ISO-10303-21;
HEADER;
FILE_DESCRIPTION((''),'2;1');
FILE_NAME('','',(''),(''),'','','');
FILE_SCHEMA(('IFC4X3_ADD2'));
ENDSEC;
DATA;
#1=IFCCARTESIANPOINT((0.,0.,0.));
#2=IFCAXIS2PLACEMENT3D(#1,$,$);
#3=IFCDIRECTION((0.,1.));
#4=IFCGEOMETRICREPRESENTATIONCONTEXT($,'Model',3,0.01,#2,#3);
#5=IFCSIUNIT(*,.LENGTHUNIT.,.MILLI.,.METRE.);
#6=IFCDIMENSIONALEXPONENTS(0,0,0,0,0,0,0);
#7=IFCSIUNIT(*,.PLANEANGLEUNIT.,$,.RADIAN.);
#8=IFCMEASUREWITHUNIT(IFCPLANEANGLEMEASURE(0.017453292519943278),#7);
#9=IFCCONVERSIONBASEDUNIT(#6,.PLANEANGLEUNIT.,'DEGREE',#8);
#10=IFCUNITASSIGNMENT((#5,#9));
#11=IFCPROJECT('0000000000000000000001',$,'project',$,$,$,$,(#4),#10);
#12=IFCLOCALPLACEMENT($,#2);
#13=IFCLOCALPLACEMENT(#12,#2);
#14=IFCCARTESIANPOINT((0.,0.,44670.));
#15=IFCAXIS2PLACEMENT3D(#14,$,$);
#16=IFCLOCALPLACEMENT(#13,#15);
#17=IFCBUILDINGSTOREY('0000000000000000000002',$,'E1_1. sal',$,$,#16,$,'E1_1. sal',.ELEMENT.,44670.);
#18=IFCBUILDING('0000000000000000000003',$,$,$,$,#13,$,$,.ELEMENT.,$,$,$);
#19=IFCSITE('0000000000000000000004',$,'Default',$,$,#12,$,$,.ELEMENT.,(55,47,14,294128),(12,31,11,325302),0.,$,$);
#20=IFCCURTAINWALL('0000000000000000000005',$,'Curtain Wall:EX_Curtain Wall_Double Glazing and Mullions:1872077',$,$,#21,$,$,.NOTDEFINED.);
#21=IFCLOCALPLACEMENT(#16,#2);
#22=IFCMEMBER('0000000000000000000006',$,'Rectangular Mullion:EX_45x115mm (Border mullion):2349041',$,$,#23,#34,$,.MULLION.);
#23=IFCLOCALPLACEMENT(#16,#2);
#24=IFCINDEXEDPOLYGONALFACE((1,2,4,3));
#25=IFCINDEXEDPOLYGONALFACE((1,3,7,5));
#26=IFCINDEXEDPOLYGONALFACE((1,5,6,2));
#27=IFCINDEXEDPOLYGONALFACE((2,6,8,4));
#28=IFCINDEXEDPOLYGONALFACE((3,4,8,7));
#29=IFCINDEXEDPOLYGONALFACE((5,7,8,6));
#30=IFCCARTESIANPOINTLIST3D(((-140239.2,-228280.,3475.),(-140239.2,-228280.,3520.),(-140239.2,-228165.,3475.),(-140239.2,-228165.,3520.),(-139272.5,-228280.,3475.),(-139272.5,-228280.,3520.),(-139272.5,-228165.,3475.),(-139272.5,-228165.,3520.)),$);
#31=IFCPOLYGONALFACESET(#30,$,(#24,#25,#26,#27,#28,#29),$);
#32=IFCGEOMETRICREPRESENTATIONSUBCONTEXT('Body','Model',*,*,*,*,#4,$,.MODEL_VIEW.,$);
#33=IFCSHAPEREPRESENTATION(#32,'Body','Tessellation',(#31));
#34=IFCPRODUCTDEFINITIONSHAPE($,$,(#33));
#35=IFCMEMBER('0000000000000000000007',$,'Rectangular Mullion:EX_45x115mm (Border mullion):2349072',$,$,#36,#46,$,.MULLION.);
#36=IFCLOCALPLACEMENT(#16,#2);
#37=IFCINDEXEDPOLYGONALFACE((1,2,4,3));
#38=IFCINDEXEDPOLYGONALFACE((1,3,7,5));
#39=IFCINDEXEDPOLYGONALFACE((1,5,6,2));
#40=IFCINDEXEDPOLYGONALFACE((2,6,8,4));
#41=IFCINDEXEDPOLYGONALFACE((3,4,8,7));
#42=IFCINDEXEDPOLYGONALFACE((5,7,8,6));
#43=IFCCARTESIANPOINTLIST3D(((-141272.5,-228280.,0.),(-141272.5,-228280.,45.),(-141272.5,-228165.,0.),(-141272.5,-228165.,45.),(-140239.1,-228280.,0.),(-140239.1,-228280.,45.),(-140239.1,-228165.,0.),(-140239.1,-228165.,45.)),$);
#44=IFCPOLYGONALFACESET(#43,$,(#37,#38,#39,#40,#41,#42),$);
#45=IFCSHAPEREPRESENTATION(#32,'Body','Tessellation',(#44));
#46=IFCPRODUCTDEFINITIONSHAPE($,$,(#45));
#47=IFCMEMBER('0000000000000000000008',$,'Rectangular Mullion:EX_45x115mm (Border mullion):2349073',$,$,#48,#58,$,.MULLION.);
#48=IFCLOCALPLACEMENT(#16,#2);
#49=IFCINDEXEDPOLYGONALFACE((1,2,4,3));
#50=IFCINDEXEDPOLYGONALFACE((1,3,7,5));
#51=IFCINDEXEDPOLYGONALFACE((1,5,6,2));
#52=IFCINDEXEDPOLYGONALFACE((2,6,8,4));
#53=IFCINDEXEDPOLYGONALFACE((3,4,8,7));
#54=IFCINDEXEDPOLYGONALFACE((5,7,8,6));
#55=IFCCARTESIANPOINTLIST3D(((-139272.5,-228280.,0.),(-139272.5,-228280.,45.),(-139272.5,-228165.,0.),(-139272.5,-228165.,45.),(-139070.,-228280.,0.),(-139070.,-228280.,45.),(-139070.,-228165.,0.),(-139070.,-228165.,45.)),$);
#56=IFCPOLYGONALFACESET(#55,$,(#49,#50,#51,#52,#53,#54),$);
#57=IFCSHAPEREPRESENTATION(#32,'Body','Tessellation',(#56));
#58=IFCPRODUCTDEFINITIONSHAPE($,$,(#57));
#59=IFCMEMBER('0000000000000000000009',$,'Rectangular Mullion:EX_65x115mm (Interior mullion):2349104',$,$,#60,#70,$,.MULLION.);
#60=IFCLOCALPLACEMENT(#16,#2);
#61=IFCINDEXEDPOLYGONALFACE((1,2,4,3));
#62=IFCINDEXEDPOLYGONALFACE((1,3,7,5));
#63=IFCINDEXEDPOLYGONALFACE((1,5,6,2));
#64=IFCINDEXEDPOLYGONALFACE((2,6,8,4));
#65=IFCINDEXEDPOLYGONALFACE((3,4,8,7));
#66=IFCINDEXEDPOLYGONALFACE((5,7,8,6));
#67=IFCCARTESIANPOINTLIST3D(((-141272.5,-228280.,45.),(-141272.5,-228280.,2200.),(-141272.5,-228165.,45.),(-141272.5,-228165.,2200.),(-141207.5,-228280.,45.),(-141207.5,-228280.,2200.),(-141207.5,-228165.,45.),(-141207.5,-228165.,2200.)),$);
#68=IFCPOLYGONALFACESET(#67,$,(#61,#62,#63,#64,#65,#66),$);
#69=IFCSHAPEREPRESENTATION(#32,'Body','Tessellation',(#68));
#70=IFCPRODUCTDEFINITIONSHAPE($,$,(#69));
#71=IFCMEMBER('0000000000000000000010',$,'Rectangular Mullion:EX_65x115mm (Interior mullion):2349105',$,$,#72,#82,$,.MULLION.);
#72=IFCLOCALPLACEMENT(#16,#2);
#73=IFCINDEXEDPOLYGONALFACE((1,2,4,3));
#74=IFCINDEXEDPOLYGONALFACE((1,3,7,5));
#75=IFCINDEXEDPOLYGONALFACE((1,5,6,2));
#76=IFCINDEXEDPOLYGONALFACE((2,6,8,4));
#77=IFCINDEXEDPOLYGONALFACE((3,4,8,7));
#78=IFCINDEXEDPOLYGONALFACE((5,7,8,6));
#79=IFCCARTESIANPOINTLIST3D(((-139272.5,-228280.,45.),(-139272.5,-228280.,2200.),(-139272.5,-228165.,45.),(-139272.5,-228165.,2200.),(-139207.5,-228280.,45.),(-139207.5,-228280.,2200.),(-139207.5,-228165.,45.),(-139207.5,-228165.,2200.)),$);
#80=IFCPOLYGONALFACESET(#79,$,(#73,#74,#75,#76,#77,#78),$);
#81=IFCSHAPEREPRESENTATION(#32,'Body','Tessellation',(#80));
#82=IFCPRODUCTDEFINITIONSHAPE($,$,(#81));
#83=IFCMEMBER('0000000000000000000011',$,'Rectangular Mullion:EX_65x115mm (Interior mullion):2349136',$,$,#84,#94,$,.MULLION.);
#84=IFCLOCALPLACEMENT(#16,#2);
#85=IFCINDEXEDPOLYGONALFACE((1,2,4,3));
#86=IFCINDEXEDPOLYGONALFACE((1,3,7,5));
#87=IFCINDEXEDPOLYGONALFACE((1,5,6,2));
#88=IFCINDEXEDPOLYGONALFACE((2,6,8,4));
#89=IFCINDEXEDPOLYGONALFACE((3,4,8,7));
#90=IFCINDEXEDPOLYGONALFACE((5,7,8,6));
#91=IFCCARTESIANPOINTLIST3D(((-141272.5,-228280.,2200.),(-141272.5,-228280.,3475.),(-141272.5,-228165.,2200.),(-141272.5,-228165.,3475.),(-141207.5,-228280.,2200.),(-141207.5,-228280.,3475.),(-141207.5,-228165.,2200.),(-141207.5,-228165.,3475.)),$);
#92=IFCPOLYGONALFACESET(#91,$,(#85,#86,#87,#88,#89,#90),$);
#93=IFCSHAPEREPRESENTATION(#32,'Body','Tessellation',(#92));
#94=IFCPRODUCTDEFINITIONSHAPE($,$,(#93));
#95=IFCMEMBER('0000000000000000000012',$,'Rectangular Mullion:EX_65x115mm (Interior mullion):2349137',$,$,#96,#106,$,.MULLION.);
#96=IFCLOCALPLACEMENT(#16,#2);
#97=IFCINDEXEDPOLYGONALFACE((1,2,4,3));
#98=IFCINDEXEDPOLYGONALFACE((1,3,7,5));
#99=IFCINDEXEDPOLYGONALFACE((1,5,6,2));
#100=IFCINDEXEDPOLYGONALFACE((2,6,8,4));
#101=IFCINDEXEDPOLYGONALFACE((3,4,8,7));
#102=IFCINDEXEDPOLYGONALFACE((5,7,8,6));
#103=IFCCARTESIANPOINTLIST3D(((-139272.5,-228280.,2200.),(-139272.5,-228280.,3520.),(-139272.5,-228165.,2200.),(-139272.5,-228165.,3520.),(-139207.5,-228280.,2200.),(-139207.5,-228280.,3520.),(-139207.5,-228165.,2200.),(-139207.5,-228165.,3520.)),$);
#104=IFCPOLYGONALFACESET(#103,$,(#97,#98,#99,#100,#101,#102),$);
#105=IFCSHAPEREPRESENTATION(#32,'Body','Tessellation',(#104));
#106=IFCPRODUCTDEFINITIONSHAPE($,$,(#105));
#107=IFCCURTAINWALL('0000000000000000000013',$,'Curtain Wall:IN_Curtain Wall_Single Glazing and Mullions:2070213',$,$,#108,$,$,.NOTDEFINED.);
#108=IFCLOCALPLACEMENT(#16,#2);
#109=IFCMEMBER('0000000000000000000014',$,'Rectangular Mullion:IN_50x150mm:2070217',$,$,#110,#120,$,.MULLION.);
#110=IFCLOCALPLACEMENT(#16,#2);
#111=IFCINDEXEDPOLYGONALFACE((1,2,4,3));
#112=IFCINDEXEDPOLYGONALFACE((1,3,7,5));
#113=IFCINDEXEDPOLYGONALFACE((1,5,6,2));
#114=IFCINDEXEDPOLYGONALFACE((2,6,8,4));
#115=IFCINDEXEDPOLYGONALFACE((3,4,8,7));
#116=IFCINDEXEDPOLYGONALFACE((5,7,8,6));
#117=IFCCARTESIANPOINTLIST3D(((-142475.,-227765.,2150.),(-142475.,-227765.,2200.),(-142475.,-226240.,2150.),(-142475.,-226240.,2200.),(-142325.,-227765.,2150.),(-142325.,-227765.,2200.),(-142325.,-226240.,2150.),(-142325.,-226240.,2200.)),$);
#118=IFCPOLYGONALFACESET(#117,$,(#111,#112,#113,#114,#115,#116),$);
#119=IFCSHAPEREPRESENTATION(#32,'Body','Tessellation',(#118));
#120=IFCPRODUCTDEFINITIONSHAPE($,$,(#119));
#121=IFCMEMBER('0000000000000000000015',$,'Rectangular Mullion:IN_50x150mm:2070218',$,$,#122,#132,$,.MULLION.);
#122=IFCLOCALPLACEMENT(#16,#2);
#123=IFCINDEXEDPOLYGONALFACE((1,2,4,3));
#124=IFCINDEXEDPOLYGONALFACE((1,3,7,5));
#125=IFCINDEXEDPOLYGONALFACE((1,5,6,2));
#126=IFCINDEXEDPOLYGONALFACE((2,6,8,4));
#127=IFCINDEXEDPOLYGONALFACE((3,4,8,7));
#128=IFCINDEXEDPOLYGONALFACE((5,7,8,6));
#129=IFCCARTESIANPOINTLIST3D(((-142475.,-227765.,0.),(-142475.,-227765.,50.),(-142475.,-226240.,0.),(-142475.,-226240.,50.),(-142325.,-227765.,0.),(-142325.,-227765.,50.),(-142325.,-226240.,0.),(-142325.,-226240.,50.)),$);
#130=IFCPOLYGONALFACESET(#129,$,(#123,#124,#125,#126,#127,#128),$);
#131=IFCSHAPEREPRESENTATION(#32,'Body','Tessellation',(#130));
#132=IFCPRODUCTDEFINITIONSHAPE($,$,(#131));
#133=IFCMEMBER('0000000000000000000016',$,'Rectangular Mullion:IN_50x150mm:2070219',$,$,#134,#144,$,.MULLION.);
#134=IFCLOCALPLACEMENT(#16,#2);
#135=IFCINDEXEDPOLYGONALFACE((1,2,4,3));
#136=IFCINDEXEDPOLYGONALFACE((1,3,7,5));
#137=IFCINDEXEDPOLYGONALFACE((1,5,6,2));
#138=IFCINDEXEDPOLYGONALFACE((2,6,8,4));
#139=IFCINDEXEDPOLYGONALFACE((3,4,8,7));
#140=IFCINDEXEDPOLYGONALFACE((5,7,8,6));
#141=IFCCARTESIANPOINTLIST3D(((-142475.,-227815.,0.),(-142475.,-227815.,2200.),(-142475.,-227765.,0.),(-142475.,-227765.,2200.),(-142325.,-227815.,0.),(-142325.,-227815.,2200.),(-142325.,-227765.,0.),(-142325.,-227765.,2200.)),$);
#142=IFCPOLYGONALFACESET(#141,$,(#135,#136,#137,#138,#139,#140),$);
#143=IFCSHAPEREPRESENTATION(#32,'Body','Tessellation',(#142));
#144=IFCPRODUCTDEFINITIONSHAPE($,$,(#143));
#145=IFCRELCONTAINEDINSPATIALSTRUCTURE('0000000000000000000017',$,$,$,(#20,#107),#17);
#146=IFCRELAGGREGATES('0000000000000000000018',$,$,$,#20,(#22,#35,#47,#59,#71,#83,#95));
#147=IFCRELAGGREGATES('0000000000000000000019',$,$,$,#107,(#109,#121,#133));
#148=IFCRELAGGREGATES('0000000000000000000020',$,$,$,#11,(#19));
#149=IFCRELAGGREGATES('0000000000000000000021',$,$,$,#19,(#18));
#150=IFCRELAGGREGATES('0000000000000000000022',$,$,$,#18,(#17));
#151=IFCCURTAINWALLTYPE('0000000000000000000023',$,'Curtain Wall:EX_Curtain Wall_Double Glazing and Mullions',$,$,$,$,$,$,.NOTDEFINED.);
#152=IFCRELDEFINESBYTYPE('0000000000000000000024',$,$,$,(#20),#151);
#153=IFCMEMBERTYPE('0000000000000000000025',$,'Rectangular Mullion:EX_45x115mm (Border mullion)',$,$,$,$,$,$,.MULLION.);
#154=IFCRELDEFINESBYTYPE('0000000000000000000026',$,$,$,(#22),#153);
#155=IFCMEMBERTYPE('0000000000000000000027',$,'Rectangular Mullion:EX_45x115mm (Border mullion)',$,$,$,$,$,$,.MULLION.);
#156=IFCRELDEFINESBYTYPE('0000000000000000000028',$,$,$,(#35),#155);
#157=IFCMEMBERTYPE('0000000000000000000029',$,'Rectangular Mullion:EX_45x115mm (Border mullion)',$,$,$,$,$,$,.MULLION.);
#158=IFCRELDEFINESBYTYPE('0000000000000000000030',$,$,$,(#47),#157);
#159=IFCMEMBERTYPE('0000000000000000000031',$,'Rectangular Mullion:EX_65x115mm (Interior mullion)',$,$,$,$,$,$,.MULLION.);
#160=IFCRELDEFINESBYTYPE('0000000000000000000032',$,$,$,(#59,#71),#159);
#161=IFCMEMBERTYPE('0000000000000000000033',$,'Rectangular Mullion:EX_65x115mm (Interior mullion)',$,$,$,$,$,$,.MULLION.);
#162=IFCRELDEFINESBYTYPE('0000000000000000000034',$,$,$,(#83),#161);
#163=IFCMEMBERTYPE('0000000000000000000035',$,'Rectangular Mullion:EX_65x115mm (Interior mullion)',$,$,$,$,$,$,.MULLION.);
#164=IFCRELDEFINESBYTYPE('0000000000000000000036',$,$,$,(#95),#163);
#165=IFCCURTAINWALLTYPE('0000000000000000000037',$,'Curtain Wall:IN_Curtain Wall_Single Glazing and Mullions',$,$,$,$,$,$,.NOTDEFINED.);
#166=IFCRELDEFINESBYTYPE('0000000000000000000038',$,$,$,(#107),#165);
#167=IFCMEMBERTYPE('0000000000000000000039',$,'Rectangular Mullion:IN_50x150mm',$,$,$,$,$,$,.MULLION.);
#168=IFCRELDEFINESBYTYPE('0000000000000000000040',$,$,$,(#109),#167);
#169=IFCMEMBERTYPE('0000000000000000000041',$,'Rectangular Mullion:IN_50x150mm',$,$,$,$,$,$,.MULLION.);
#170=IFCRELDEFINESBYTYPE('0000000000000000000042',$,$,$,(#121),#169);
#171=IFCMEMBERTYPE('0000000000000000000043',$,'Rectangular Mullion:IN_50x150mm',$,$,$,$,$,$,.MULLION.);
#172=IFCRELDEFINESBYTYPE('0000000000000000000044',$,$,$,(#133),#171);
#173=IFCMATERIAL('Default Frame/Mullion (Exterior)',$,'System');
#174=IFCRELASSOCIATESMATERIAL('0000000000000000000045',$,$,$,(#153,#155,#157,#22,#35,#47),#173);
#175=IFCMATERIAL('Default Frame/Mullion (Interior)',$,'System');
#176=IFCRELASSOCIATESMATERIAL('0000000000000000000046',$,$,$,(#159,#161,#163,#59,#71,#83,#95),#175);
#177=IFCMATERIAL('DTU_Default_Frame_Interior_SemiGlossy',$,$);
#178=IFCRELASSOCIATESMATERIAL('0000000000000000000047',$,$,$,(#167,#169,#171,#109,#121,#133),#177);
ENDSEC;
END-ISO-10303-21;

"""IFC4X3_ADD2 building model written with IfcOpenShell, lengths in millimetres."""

from ifc_helpers import new_model, entity, si_unit, converted_unit, direction, frame, origin, origin_2d_with_axis, place, context, subcontext, project, spatial, rectangle, extrude, source, transform, mapped, material, material_profile, profile_set, profile_usage, type_object, type_shapes, element, aggregate, save


model = new_model("IFC4X3_ADD2")

# Units and contexts
model_context = context("Model", 3, precision=0.01, world=origin(), true_north=direction((0.0, 1.0)))
body_context = subcontext(model_context, "Body", "Model", "MODEL_VIEW")
ifc_project = project(units=[si_unit("LENGTHUNIT", "METRE", prefix="MILLI"), converted_unit("PLANEANGLEUNIT", "DEGREE", entity("IfcPlaneAngleMeasure", 0.017453292519943278), si_unit("PLANEANGLEUNIT", "RADIAN"), dimensions=[0, 0, 0, 0, 0, 0, 0])], contexts=[model_context])

# Site, building, storey
site_placement = place(None, origin())
site = spatial("IfcSite", under=ifc_project, at=site_placement, Name="Default", CompositionType="ELEMENT", RefLatitude=(55, 47, 14, 294128), RefLongitude=(12, 31, 11, 325302), RefElevation=0.0)
building_placement = place(site_placement, origin())
building = spatial("IfcBuilding", under=site, at=building_placement, CompositionType="ELEMENT")
storey_placement = place(building_placement, frame((0.0, 0.0, 44670.0)))
storey = spatial("IfcBuildingStorey", under=building, at=storey_placement, Name="E1_1. sal", LongName="E1_1. sal", CompositionType="ELEMENT", Elevation=44670.0)

# Curtain walls, members
curtain_wall_type_1 = type_object("IfcCurtainWallType", Name="Curtain Wall:EX_Curtain Wall_Double Glazing and Mullions", PredefinedType="NOTDEFINED")
curtain_wall_1_placement = place(storey_placement, frame((0.0, 0.0, -44670.0)))
curtain_wall_1 = element("IfcCurtainWall", 1, at=curtain_wall_1_placement, inside=storey, type_object=curtain_wall_type_1, Name="Curtain Wall:EX_Curtain Wall_Double Glazing and Mullions:1872077", PredefinedType="NOTDEFINED")
ifc_material_1 = material(Name="Default Frame/Mullion (Interior)", Category="System")
ifc_material_profile_1 = material_profile(ifc_material_1, rectangle(XDim=65.0, YDim=115.0, at=origin_2d_with_axis()), Name="EX_65x115mm (Interior mullion)")
ifc_profile_set_1 = profile_set([ifc_material_profile_1], Name="EX_65x115mm (Interior mullion)")
ifc_profile_usage_1 = profile_usage(ifc_profile_set_1)
ifc_material_2 = material(Name="Default Frame/Mullion (Exterior)", Category="System")
ifc_material_profile_2 = material_profile(ifc_material_2, rectangle(XDim=45.0, YDim=115.0, at=origin_2d_with_axis()), Name="EX_45x115mm (Border mullion)")
ifc_profile_set_2 = profile_set([ifc_material_profile_2], Name="EX_45x115mm (Border mullion)")
ifc_profile_usage_2 = profile_usage(ifc_profile_set_2)
member_type_1 = type_object("IfcMemberType", Name="Rectangular Mullion:EX_45x115mm (Border mullion)", PredefinedType="MULLION", material=ifc_profile_set_2)
shared_shape_1 = source(origin(), body_context, "Body", "SweptSolid", [
    extrude(rectangle(XDim=45.0, YDim=115.0, at=origin_2d_with_axis()), frame((-22.5, -57.5, -966.7), z_axis=(0.0, 0.0, 1.0), x_axis=(-1.0, 0.0, 0.0)), (0.0, 0.0, 1.0), 966.7),
])
type_shapes(member_type_1, [shared_shape_1])
member_1_placement = place(curtain_wall_1_placement, frame((-139272.5, -228280.0, 48190.0), z_axis=(1.0, 0.0, 0.0), x_axis=(0.0, 0.0, 1.0)))
member_1 = element("IfcMember", 2, at=member_1_placement, type_object=member_type_1, material=ifc_profile_usage_2, Name="Rectangular Mullion:EX_45x115mm (Border mullion):2349041", PredefinedType="MULLION", context=body_context, shape_type="MappedRepresentation", body=[
    mapped(shared_shape_1, transform((0.0, 0.0, 0.0), scale=1.0)),
])
member_type_2 = type_object("IfcMemberType", Name="Rectangular Mullion:EX_45x115mm (Border mullion)", PredefinedType="MULLION", material=ifc_profile_set_2)
shared_shape_2 = source(origin(), body_context, "Body", "SweptSolid", [
    extrude(rectangle(XDim=45.0, YDim=115.0, at=origin_2d_with_axis()), frame((-22.5, -57.5, -1033.4), z_axis=(0.0, 0.0, 1.0), x_axis=(-1.0, 0.0, 0.0)), (0.0, 0.0, 1.0), 1033.4),
])
type_shapes(member_type_2, [shared_shape_2])
member_2_placement = place(curtain_wall_1_placement, frame((-141272.5, -228280.0, 44670.0), z_axis=(-1.0, 0.0, 0.0), x_axis=(0.0, 0.0, -1.0)))
member_2 = element("IfcMember", 3, at=member_2_placement, type_object=member_type_2, material=ifc_profile_usage_2, Name="Rectangular Mullion:EX_45x115mm (Border mullion):2349072", PredefinedType="MULLION", context=body_context, shape_type="MappedRepresentation", body=[
    mapped(shared_shape_2, transform((0.0, 0.0, 0.0), scale=1.0)),
])
member_type_3 = type_object("IfcMemberType", Name="Rectangular Mullion:EX_45x115mm (Border mullion)", PredefinedType="MULLION", material=ifc_profile_set_2)
shared_shape_3 = source(origin(), body_context, "Body", "SweptSolid", [
    extrude(rectangle(XDim=45.0, YDim=115.0, at=origin_2d_with_axis()), frame((-22.5, -57.5, -202.5), z_axis=(0.0, 0.0, 1.0), x_axis=(-1.0, 0.0, 0.0)), (0.0, 0.0, 1.0), 202.5),
])
type_shapes(member_type_3, [shared_shape_3])
member_3_placement = place(curtain_wall_1_placement, frame((-139272.5, -228280.0, 44670.0), z_axis=(-1.0, 0.0, 0.0), x_axis=(0.0, 0.0, -1.0)))
member_3 = element("IfcMember", 4, at=member_3_placement, type_object=member_type_3, material=ifc_profile_usage_2, Name="Rectangular Mullion:EX_45x115mm (Border mullion):2349073", PredefinedType="MULLION", context=body_context, shape_type="MappedRepresentation", body=[
    mapped(shared_shape_3, transform((0.0, 0.0, 0.0), scale=1.0)),
])
member_type_4 = type_object("IfcMemberType", Name="Rectangular Mullion:EX_65x115mm (Interior mullion)", PredefinedType="MULLION", material=ifc_profile_set_1)
shared_shape_4 = source(origin(), body_context, "Body", "SweptSolid", [
    extrude(rectangle(XDim=65.0, YDim=115.0, at=origin_2d_with_axis()), frame((0.0, -57.5, -2155.0), z_axis=(0.0, 0.0, 1.0), x_axis=(-1.0, 0.0, 0.0)), (0.0, 0.0, 1.0), 2155.0),
])
type_shapes(member_type_4, [shared_shape_4])
member_4_placement = place(curtain_wall_1_placement, frame((-141240.0, -228280.0, 44715.0), z_axis=(0.0, 0.0, -1.0), x_axis=(1.0, 0.0, 0.0)))
member_4 = element("IfcMember", 5, at=member_4_placement, type_object=member_type_4, material=ifc_profile_usage_1, Name="Rectangular Mullion:EX_65x115mm (Interior mullion):2349104", PredefinedType="MULLION", context=body_context, shape_type="MappedRepresentation", body=[
    mapped(shared_shape_4, transform((0.0, 0.0, 0.0), scale=1.0)),
])
member_5_placement = place(curtain_wall_1_placement, frame((-139240.0, -228280.0, 44715.0), z_axis=(0.0, 0.0, -1.0), x_axis=(1.0, 0.0, 0.0)))
member_5 = element("IfcMember", 6, at=member_5_placement, type_object=member_type_4, material=ifc_profile_usage_1, Name="Rectangular Mullion:EX_65x115mm (Interior mullion):2349105", PredefinedType="MULLION", context=body_context, shape_type="MappedRepresentation", body=[
    mapped(shared_shape_4, transform((0.0, 0.0, 0.0), scale=1.0)),
])
member_type_5 = type_object("IfcMemberType", Name="Rectangular Mullion:EX_65x115mm (Interior mullion)", PredefinedType="MULLION", material=ifc_profile_set_1)
shared_shape_5 = source(origin(), body_context, "Body", "SweptSolid", [
    extrude(rectangle(XDim=65.0, YDim=115.0, at=origin_2d_with_axis()), frame((0.0, -57.5, -1275.0), z_axis=(0.0, 0.0, 1.0), x_axis=(-1.0, 0.0, 0.0)), (0.0, 0.0, 1.0), 1275.0),
])
type_shapes(member_type_5, [shared_shape_5])
member_6_placement = place(curtain_wall_1_placement, frame((-141240.0, -228280.0, 46870.0), z_axis=(0.0, 0.0, -1.0), x_axis=(1.0, 0.0, 0.0)))
member_6 = element("IfcMember", 7, at=member_6_placement, type_object=member_type_5, material=ifc_profile_usage_1, Name="Rectangular Mullion:EX_65x115mm (Interior mullion):2349136", PredefinedType="MULLION", context=body_context, shape_type="MappedRepresentation", body=[
    mapped(shared_shape_5, transform((0.0, 0.0, 0.0), scale=1.0)),
])
member_type_6 = type_object("IfcMemberType", Name="Rectangular Mullion:EX_65x115mm (Interior mullion)", PredefinedType="MULLION", material=ifc_profile_set_1)
shared_shape_6 = source(origin(), body_context, "Body", "SweptSolid", [
    extrude(rectangle(XDim=65.0, YDim=115.0, at=origin_2d_with_axis()), frame((0.0, -57.5, -1320.0), z_axis=(0.0, 0.0, 1.0), x_axis=(-1.0, 0.0, 0.0)), (0.0, 0.0, 1.0), 1320.0),
])
type_shapes(member_type_6, [shared_shape_6])
member_7_placement = place(curtain_wall_1_placement, frame((-139240.0, -228280.0, 46870.0), z_axis=(0.0, 0.0, -1.0), x_axis=(1.0, 0.0, 0.0)))
member_7 = element("IfcMember", 8, at=member_7_placement, type_object=member_type_6, material=ifc_profile_usage_1, Name="Rectangular Mullion:EX_65x115mm (Interior mullion):2349137", PredefinedType="MULLION", context=body_context, shape_type="MappedRepresentation", body=[
    mapped(shared_shape_6, transform((0.0, 0.0, 0.0), scale=1.0)),
])
curtain_wall_type_2 = type_object("IfcCurtainWallType", Name="Curtain Wall:IN_Curtain Wall_Single Glazing and Mullions", PredefinedType="NOTDEFINED")
curtain_wall_2_placement = place(storey_placement, frame((0.0, 0.0, -44670.0)))
curtain_wall_2 = element("IfcCurtainWall", 9, at=curtain_wall_2_placement, inside=storey, type_object=curtain_wall_type_2, Name="Curtain Wall:IN_Curtain Wall_Single Glazing and Mullions:2070213", PredefinedType="NOTDEFINED")
ifc_material_3 = material(Name="DTU_Default_Frame_Interior_SemiGlossy")
ifc_material_profile_3 = material_profile(ifc_material_3, rectangle(XDim=50.0, YDim=150.0, at=origin_2d_with_axis()), Name="IN_50x150mm")
ifc_profile_set_3 = profile_set([ifc_material_profile_3], Name="IN_50x150mm")
ifc_profile_usage_3 = profile_usage(ifc_profile_set_3)
member_type_7 = type_object("IfcMemberType", Name="Rectangular Mullion:IN_50x150mm", PredefinedType="MULLION", material=ifc_profile_set_3)
shared_shape_7 = source(origin(), body_context, "Body", "SweptSolid", [
    extrude(rectangle(XDim=50.0, YDim=150.0, at=origin_2d_with_axis()), frame((-25.0, 0.0, -1525.0), z_axis=(0.0, 0.0, 1.0), x_axis=(-1.0, 0.0, 0.0)), (0.0, 0.0, 1.0), 1525.0),
])
type_shapes(member_type_7, [shared_shape_7])
member_8_placement = place(curtain_wall_2_placement, frame((-142400.0, -227765.0, 46870.0), z_axis=(0.0, -1.0, 0.0), x_axis=(0.0, 0.0, 1.0)))
member_8 = element("IfcMember", 10, at=member_8_placement, type_object=member_type_7, material=ifc_profile_usage_3, Name="Rectangular Mullion:IN_50x150mm:2070217", PredefinedType="MULLION", context=body_context, shape_type="MappedRepresentation", body=[
    mapped(shared_shape_7, transform((0.0, 0.0, 0.0), scale=1.0)),
])
member_type_8 = type_object("IfcMemberType", Name="Rectangular Mullion:IN_50x150mm", PredefinedType="MULLION", material=ifc_profile_set_3)
shared_shape_8 = source(origin(), body_context, "Body", "SweptSolid", [
    extrude(rectangle(XDim=50.0, YDim=150.0, at=origin_2d_with_axis()), frame((-25.0, 0.0, -1525.0), z_axis=(0.0, 0.0, 1.0), x_axis=(-1.0, 0.0, 0.0)), (0.0, 0.0, 1.0), 1525.0),
])
type_shapes(member_type_8, [shared_shape_8])
member_9_placement = place(curtain_wall_2_placement, frame((-142400.0, -226240.0, 44670.0), z_axis=(0.0, 1.0, 0.0), x_axis=(0.0, 0.0, -1.0)))
member_9 = element("IfcMember", 11, at=member_9_placement, type_object=member_type_8, material=ifc_profile_usage_3, Name="Rectangular Mullion:IN_50x150mm:2070218", PredefinedType="MULLION", context=body_context, shape_type="MappedRepresentation", body=[
    mapped(shared_shape_8, transform((0.0, 0.0, 0.0), scale=1.0)),
])
member_type_9 = type_object("IfcMemberType", Name="Rectangular Mullion:IN_50x150mm", PredefinedType="MULLION", material=ifc_profile_set_3)
shared_shape_9 = source(origin(), body_context, "Body", "SweptSolid", [
    extrude(rectangle(XDim=50.0, YDim=150.0, at=origin_2d_with_axis()), frame((-25.0, 0.0, -2200.0), z_axis=(0.0, 0.0, 1.0), x_axis=(-1.0, 0.0, 0.0)), (0.0, 0.0, 1.0), 2200.0),
])
type_shapes(member_type_9, [shared_shape_9])
member_10_placement = place(curtain_wall_2_placement, frame((-142400.0, -227815.0, 44670.0), z_axis=(0.0, 0.0, -1.0), x_axis=(0.0, -1.0, 0.0)))
member_10 = element("IfcMember", 12, at=member_10_placement, type_object=member_type_9, material=ifc_profile_usage_3, Name="Rectangular Mullion:IN_50x150mm:2070219", PredefinedType="MULLION", context=body_context, shape_type="MappedRepresentation", body=[
    mapped(shared_shape_9, transform((0.0, 0.0, 0.0), scale=1.0)),
])

aggregate(curtain_wall_1, [member_1, member_2, member_3, member_4, member_5, member_6, member_7])
aggregate(curtain_wall_2, [member_8, member_9, member_10])

save(model, "model.ifc")
